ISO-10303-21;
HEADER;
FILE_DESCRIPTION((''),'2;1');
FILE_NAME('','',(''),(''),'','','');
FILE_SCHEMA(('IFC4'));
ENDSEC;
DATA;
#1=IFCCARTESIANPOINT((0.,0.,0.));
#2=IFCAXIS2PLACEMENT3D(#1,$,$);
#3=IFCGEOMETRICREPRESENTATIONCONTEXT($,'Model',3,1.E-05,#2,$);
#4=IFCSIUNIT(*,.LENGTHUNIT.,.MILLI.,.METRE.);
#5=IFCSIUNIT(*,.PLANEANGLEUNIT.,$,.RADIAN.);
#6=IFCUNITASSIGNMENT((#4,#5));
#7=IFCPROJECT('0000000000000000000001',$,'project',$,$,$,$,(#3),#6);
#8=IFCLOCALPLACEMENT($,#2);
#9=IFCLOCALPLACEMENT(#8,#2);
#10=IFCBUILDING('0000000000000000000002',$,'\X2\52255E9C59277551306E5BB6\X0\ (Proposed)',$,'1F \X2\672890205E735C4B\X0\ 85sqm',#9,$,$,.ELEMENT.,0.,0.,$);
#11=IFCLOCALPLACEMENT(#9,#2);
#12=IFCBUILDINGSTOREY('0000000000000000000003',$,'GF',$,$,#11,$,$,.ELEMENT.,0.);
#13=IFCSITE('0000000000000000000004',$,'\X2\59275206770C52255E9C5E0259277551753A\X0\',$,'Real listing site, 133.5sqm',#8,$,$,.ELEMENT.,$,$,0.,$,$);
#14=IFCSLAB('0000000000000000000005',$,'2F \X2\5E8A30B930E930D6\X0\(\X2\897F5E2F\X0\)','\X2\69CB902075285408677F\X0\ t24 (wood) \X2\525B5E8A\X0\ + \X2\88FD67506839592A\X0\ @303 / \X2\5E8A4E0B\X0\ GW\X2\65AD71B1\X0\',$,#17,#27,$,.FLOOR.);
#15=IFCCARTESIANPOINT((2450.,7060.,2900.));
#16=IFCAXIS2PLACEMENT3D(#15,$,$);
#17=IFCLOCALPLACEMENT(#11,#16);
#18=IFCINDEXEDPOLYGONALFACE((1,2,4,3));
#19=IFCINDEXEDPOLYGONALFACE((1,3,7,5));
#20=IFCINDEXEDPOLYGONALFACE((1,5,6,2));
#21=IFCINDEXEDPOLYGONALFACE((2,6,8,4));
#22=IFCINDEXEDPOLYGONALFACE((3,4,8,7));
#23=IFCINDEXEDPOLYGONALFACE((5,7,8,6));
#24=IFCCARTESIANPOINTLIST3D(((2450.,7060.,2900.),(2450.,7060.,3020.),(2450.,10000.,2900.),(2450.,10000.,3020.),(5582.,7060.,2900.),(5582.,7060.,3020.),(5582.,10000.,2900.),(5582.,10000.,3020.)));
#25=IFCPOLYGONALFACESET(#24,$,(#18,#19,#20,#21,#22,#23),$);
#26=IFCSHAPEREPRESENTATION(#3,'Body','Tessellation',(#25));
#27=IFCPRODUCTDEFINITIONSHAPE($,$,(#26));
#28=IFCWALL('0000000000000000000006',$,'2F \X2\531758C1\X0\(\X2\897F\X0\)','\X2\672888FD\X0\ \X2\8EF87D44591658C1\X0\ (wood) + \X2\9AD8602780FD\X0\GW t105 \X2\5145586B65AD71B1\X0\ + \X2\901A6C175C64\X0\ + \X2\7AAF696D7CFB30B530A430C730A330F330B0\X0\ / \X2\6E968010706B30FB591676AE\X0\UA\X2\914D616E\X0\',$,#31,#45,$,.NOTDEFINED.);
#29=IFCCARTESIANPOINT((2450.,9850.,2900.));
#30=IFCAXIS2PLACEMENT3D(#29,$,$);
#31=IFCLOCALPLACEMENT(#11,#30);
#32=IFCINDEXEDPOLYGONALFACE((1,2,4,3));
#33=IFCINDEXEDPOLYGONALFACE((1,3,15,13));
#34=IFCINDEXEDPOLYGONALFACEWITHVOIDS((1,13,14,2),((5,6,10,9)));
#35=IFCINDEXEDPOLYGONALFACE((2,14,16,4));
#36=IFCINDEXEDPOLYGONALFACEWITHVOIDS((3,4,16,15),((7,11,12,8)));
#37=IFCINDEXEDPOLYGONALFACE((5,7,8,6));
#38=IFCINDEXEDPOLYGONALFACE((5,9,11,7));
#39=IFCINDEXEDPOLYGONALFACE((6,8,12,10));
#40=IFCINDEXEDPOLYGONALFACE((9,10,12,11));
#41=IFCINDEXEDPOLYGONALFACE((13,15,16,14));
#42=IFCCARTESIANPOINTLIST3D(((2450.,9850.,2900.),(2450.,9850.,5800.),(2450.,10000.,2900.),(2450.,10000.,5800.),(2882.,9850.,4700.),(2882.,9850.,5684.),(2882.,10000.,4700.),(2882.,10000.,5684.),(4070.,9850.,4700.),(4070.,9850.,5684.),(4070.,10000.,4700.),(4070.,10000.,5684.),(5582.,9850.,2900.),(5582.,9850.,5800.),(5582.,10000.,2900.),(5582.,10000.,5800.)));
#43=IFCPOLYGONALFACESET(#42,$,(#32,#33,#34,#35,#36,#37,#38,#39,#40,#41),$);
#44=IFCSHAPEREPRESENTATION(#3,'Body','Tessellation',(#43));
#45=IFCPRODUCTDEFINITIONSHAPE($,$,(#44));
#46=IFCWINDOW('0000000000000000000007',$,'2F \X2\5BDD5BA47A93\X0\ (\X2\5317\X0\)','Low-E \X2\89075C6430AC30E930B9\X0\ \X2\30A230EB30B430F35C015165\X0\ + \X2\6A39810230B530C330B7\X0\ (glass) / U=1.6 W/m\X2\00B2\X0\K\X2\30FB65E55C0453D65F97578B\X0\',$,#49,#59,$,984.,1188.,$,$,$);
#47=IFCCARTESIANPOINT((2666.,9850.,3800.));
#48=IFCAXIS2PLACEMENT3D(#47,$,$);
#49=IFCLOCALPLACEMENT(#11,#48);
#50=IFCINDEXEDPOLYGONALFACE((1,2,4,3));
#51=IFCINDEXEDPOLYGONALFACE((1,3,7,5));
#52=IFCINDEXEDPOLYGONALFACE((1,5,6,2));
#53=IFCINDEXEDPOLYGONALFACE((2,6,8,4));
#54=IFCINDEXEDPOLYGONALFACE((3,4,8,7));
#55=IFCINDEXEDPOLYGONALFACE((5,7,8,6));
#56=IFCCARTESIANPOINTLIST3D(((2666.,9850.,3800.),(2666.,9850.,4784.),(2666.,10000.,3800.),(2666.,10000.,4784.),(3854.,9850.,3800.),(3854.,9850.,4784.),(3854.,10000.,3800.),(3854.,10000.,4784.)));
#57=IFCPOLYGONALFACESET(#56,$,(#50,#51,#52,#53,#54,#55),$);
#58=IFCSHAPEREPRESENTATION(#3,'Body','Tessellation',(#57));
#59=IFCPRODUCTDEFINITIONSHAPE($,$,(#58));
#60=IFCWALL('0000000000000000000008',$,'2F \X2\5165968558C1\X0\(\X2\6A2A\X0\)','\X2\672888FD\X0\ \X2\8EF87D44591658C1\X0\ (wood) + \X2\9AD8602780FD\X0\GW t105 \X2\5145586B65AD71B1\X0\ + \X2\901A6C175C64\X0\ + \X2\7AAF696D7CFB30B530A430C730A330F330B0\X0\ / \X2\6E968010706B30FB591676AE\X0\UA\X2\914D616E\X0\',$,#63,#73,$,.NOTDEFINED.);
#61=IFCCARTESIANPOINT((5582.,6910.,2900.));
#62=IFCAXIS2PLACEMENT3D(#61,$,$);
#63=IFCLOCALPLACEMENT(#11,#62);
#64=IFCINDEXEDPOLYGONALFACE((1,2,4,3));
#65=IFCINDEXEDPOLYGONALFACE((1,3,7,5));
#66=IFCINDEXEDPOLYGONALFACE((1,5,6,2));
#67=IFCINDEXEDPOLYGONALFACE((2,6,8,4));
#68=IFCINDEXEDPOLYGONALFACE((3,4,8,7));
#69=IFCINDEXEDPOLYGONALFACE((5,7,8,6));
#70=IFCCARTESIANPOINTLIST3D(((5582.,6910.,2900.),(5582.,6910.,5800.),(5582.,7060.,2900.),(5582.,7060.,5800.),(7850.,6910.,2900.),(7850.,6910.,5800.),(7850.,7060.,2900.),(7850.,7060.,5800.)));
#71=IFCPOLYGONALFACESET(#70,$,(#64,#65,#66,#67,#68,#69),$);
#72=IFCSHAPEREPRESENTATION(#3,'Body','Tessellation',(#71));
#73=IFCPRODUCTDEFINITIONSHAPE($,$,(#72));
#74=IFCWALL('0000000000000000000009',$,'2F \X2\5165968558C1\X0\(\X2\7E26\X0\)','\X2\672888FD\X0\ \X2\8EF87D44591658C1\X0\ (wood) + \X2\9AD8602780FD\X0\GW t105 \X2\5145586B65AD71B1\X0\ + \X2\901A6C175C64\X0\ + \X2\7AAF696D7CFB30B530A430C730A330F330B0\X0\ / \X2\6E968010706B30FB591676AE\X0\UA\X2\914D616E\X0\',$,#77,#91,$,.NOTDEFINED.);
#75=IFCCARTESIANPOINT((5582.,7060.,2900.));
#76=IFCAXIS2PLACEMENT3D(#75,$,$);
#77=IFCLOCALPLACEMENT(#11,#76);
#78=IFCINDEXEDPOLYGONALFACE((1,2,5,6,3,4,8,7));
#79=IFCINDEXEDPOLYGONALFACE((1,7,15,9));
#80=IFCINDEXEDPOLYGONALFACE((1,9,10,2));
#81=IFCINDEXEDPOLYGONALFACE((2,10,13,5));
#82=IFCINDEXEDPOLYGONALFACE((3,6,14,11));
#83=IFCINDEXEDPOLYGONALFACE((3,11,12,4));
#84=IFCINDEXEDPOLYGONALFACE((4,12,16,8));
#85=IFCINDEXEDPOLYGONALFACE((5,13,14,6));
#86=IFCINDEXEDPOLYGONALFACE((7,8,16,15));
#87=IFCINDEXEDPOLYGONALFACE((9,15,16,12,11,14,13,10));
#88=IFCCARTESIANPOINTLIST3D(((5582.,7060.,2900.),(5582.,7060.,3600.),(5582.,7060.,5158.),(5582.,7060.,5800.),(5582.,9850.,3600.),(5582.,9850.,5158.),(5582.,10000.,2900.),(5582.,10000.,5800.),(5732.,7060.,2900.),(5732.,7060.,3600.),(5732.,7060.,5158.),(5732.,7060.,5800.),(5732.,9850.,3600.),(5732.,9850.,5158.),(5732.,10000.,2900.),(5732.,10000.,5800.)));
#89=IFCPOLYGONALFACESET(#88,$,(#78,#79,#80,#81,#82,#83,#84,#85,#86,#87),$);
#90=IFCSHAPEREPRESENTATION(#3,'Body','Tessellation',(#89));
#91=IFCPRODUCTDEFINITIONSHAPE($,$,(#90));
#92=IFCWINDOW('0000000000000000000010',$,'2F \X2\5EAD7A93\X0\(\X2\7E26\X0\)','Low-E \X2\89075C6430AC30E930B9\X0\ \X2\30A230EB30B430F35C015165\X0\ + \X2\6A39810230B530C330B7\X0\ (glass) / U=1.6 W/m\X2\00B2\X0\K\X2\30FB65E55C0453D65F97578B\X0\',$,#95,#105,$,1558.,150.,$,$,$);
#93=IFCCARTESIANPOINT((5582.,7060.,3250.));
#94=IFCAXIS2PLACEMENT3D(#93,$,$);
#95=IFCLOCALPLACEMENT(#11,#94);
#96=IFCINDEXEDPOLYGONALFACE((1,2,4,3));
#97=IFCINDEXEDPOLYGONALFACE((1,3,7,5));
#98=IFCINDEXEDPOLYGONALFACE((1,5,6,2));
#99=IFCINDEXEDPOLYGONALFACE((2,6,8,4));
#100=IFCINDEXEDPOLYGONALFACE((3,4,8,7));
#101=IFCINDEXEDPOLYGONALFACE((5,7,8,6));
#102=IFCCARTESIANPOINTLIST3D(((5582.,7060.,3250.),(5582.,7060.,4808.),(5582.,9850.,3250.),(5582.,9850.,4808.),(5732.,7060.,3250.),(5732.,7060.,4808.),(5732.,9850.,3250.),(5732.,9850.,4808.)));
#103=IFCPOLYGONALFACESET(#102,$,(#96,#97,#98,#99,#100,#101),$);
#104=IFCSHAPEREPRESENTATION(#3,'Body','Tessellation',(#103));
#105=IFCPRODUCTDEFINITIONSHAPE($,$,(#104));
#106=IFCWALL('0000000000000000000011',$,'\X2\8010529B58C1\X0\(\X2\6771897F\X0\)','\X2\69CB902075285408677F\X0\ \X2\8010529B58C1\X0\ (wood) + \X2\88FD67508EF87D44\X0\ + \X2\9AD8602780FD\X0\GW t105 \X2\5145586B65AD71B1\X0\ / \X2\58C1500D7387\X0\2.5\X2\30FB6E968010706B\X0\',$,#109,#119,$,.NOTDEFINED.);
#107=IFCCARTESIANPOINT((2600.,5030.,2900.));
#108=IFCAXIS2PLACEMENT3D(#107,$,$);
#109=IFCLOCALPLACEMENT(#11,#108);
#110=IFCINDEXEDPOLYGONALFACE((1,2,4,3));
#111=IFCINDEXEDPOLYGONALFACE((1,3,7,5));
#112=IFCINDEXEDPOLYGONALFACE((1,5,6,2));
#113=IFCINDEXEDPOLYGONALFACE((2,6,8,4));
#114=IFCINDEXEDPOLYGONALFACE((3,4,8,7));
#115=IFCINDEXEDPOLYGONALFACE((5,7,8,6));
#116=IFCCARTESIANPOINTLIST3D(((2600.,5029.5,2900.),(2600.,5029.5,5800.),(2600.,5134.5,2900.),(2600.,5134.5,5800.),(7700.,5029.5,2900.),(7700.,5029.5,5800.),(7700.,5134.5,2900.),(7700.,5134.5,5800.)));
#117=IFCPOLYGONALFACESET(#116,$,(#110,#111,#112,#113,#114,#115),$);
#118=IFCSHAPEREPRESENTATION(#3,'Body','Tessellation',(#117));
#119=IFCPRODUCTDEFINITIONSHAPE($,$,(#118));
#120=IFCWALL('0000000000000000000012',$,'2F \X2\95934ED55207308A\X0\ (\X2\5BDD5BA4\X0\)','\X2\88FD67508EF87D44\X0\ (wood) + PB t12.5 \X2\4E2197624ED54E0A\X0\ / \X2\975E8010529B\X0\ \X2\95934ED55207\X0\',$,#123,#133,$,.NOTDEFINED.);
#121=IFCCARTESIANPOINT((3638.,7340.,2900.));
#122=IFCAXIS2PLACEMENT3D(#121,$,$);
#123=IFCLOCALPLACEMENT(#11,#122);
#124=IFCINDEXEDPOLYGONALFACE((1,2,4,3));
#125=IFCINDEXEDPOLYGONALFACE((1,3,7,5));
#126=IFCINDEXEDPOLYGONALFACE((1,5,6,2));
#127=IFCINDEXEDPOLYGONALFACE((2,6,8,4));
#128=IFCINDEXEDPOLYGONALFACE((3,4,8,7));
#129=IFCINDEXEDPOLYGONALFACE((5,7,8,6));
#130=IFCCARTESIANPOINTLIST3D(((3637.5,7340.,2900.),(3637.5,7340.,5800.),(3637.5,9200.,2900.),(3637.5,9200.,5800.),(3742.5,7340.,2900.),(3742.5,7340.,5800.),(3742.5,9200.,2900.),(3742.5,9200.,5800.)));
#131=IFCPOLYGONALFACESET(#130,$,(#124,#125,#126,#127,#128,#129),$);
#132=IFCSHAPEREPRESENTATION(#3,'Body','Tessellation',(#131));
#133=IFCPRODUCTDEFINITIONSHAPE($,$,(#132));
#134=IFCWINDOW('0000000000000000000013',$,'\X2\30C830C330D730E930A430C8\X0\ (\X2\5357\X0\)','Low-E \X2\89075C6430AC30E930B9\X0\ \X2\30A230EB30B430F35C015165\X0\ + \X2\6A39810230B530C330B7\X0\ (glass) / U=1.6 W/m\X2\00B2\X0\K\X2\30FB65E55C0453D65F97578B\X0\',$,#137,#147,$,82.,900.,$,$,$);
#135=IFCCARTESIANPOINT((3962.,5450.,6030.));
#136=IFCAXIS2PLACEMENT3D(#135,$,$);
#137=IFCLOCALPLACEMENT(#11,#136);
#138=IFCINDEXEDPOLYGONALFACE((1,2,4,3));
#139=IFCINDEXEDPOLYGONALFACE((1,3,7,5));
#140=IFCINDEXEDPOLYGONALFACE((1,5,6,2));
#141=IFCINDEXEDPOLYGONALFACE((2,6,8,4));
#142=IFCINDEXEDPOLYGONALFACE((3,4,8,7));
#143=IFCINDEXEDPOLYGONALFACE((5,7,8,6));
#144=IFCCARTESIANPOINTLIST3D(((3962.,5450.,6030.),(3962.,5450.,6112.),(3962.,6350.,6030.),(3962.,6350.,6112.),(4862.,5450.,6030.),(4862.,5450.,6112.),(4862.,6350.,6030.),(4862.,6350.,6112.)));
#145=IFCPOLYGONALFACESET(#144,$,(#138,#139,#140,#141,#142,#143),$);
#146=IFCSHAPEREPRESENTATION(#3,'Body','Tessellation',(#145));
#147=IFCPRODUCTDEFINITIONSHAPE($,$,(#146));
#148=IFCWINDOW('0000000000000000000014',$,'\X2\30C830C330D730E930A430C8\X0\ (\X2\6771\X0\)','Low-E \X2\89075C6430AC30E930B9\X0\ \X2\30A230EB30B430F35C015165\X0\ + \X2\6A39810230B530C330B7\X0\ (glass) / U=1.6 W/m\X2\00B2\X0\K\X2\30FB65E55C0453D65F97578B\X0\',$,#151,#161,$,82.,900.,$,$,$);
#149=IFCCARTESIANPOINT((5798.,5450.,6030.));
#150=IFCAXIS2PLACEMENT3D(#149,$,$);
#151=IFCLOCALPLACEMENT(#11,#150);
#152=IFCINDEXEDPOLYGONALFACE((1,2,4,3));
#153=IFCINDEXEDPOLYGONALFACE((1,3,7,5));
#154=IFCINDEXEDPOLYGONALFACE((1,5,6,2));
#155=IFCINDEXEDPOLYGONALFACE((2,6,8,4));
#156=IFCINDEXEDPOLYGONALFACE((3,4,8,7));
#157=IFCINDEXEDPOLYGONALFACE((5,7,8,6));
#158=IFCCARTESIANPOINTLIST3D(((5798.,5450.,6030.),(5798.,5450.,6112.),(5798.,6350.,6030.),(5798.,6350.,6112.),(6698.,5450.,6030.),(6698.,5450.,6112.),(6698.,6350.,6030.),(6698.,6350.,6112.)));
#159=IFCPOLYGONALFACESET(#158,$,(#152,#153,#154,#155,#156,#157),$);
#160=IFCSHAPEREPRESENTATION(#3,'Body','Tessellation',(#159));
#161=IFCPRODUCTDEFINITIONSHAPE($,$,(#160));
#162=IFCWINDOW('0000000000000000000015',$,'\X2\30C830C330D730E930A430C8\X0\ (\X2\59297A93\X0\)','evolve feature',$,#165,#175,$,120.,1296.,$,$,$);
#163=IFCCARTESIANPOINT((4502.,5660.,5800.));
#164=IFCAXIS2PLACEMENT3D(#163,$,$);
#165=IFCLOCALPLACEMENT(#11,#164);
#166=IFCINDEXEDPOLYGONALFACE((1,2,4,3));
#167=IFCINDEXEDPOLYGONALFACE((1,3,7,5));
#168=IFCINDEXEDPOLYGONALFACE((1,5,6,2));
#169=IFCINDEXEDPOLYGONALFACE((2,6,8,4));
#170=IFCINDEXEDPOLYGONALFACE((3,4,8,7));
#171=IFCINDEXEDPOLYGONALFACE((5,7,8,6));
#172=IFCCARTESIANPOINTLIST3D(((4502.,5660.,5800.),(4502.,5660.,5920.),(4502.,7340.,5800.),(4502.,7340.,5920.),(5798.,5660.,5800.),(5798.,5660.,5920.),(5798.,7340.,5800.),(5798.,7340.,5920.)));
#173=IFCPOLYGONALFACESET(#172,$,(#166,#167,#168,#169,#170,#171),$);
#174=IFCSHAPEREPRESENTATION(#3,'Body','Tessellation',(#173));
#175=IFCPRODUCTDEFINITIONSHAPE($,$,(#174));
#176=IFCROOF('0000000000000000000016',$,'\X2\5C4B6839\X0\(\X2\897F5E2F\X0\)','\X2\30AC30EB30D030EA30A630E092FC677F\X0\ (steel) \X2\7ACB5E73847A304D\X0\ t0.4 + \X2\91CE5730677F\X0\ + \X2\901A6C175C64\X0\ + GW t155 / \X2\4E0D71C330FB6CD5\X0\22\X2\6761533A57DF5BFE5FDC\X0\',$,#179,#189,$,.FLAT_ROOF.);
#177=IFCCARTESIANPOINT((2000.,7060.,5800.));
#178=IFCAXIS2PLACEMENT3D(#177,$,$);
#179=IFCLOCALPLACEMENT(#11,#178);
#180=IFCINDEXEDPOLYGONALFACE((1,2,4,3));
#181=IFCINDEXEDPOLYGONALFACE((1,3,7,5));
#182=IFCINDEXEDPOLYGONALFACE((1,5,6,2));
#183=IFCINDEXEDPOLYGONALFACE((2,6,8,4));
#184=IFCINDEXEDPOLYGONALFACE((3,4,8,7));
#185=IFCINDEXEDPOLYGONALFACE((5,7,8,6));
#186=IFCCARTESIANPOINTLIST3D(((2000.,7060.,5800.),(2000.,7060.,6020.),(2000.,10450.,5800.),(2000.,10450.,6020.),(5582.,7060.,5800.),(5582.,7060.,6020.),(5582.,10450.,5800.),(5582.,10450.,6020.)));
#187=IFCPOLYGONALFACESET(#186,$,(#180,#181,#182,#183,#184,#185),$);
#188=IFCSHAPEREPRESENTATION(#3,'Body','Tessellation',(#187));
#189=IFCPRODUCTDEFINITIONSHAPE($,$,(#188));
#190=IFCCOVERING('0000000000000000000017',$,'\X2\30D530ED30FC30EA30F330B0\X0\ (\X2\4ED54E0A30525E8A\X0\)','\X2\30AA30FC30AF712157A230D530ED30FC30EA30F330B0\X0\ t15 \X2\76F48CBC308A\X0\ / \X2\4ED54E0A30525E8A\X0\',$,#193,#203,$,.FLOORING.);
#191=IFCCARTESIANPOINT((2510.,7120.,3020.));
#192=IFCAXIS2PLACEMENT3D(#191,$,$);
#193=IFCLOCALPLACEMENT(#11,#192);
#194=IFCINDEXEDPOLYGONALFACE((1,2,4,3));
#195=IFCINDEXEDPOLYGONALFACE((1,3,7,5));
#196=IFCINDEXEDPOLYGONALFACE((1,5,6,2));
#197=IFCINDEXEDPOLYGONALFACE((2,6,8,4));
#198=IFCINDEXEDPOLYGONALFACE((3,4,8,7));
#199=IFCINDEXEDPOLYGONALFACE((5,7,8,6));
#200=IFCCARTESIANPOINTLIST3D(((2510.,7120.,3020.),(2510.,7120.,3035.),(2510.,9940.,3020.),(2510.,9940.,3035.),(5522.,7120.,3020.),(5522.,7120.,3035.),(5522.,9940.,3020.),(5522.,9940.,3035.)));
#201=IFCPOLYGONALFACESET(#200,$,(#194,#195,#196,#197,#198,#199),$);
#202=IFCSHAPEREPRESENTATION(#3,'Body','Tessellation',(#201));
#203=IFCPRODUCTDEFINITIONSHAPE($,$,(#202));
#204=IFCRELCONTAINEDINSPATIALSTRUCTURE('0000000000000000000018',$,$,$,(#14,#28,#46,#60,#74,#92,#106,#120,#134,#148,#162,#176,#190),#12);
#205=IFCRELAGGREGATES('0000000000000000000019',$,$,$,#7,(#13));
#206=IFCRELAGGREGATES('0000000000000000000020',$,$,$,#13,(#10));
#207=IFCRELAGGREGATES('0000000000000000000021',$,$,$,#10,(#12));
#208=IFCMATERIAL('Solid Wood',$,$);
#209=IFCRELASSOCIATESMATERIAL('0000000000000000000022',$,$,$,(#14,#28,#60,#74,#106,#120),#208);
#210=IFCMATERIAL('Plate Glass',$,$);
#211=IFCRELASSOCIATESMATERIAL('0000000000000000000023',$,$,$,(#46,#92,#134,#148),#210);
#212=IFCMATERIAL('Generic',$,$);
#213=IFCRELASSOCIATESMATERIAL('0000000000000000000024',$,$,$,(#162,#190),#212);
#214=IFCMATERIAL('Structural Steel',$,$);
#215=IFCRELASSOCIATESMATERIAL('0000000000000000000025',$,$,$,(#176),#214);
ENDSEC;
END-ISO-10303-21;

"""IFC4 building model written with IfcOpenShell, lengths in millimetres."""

from ifc_helpers import new_model, si_unit, frame, frame_2d, origin, place, context, project, spatial, rectangle, extrude, material, element, fill, save


model = new_model("IFC4")

# Units and contexts
model_context = context("Model", 3, precision=1e-05, world=origin())
ifc_project = project(units=[si_unit("LENGTHUNIT", "METRE", prefix="MILLI"), si_unit("PLANEANGLEUNIT", "RADIAN")], contexts=[model_context])

# Site, building, storey
site_placement = place(None, origin())
site = spatial("IfcSite", under=ifc_project, at=site_placement, Name="大分県別府市大畑町", ObjectType="Real listing site, 133.5sqm", CompositionType="ELEMENT", RefElevation=0.0)
building_placement = place(site_placement, origin())
building = spatial("IfcBuilding", under=site, at=building_placement, Name="別府大畑の家 (Proposed)", ObjectType="1F 木造平屋 85sqm", CompositionType="ELEMENT", ElevationOfRefHeight=0.0, ElevationOfTerrain=0.0)
storey_placement = place(building_placement, origin())
storey = spatial("IfcBuildingStorey", under=building, at=storey_placement, Name="GF", CompositionType="ELEMENT", Elevation=0.0)

# Slab
ifc_material_1 = material(Name="Solid Wood")
slab_placement = place(storey_placement, frame((2450.0, 7060.0, 2900.0)))
element("IfcSlab", 1, at=slab_placement, inside=storey, material=ifc_material_1, Name="2F 床スラブ(西帯)", Description="構造用合板 t24 (wood) 剛床 + 製材根太 @303 / 床下 GW断熱", PredefinedType="FLOOR", context=model_context, shape_type="SweptSolid", body=[
    extrude(rectangle(XDim=3132.0, YDim=2940.0, at=frame_2d((1566.0, 1470.0))), frame((2450.0, 7060.0, 2900.0)), (0.0, 0.0, 1.0), 120.0),
])

# Wall, opening, window
wall_1_placement = place(storey_placement, frame((2450.0, 9850.0, 2900.0)))
wall_1 = element("IfcWall", 2, at=wall_1_placement, inside=storey, material=ifc_material_1, Name="2F 北壁(西)", Description="木製 軸組外壁 (wood) + 高性能GW t105 充填断熱 + 通気層 + 窯業系サイディング / 準耐火・外皮UA配慮", PredefinedType="NOTDEFINED", context=model_context, shape_type="SweptSolid", body=[
    extrude(rectangle(XDim=3132.0, YDim=150.0, at=frame_2d((1566.0, 75.0))), frame((2450.0, 9850.0, 2900.0)), (0.0, 0.0, 1.0), 2900.0),
])
opening_1_placement = place(storey_placement, frame((2666.0, 9850.0, 3800.0)))
opening_1 = element("IfcOpeningElement", 3, at=opening_1_placement, cuts=wall_1, PredefinedType="NOTDEFINED", context=model_context, shape_type="SweptSolid", body=[
    extrude(rectangle(XDim=1188.0, YDim=150.0, at=frame_2d((594.0, 75.0))), frame((2666.0, 9850.0, 3800.0)), (0.0, 0.0, 1.0), 984.0),
])
ifc_material_2 = material(Name="Plate Glass")
window_1_placement = place(storey_placement, frame((2666.0, 9850.0, 3800.0)))
window_1 = element("IfcWindow", 4, at=window_1_placement, inside=storey, material=ifc_material_2, Name="2F 寝室窓 (北)", Description="Low-E 複層ガラス アルゴン封入 + 樹脂サッシ (glass) / U=1.6 W/m²K・日射取得型", OverallHeight=984.0, OverallWidth=1188.0, context=model_context, shape_type="SweptSolid", body=[
    extrude(rectangle(XDim=1188.0, YDim=150.0, at=frame_2d((594.0, 75.0))), frame((2666.0, 9850.0, 3800.0)), (0.0, 0.0, 1.0), 984.0),
])
fill(opening_1, window_1)

# Wall
wall_2_placement = place(storey_placement, frame((5582.0, 6910.0, 2900.0)))
element("IfcWall", 5, at=wall_2_placement, inside=storey, material=ifc_material_1, Name="2F 入隅壁(横)", Description="木製 軸組外壁 (wood) + 高性能GW t105 充填断熱 + 通気層 + 窯業系サイディング / 準耐火・外皮UA配慮", PredefinedType="NOTDEFINED", context=model_context, shape_type="SweptSolid", body=[
    extrude(rectangle(XDim=2268.0, YDim=150.0, at=frame_2d((1134.0, 75.0))), frame((5582.0, 6910.0, 2900.0)), (0.0, 0.0, 1.0), 2900.0),
])

# Wall, opening, window
wall_3_placement = place(storey_placement, frame((5582.0, 7060.0, 2900.0)))
wall_3 = element("IfcWall", 6, at=wall_3_placement, inside=storey, material=ifc_material_1, Name="2F 入隅壁(縦)", Description="木製 軸組外壁 (wood) + 高性能GW t105 充填断熱 + 通気層 + 窯業系サイディング / 準耐火・外皮UA配慮", PredefinedType="NOTDEFINED", context=model_context, shape_type="SweptSolid", body=[
    extrude(rectangle(XDim=150.0, YDim=2940.0, at=frame_2d((75.0, 1470.0))), frame((5582.0, 7060.0, 2900.0)), (0.0, 0.0, 1.0), 2900.0),
])
opening_2_placement = place(storey_placement, frame((5582.0, 7060.0, 3250.0)))
opening_2 = element("IfcOpeningElement", 7, at=opening_2_placement, cuts=wall_3, PredefinedType="NOTDEFINED", context=model_context, shape_type="SweptSolid", body=[
    extrude(rectangle(XDim=150.0, YDim=2790.0, at=frame_2d((75.0, 1395.0))), frame((5582.0, 7060.0, 3250.0)), (0.0, 0.0, 1.0), 1558.0),
])
window_2_placement = place(storey_placement, frame((5582.0, 7060.0, 3250.0)))
window_2 = element("IfcWindow", 8, at=window_2_placement, inside=storey, material=ifc_material_2, Name="2F 庭窓(縦)", Description="Low-E 複層ガラス アルゴン封入 + 樹脂サッシ (glass) / U=1.6 W/m²K・日射取得型", OverallHeight=1558.0, OverallWidth=150.0, context=model_context, shape_type="SweptSolid", body=[
    extrude(rectangle(XDim=150.0, YDim=2790.0, at=frame_2d((75.0, 1395.0))), frame((5582.0, 7060.0, 3250.0)), (0.0, 0.0, 1.0), 1558.0),
])
fill(opening_2, window_2)

# Walls
wall_4_placement = place(storey_placement, frame((2600.0, 5030.0, 2900.0)))
element("IfcWall", 9, at=wall_4_placement, inside=storey, material=ifc_material_1, Name="耐力壁(東西)", Description="構造用合板 耐力壁 (wood) + 製材軸組 + 高性能GW t105 充填断熱 / 壁倍率2.5・準耐火", PredefinedType="NOTDEFINED", context=model_context, shape_type="SweptSolid", body=[
    extrude(rectangle(XDim=5100.0, YDim=105.0, at=frame_2d((2550.0, 52.0))), frame((2600.0, 5030.0, 2900.0)), (0.0, 0.0, 1.0), 2900.0),
])
wall_5_placement = place(storey_placement, frame((3638.0, 7340.0, 2900.0)))
element("IfcWall", 10, at=wall_5_placement, inside=storey, material=ifc_material_1, Name="2F 間仕切り (寝室)", Description="製材軸組 (wood) + PB t12.5 両面仕上 / 非耐力 間仕切", PredefinedType="NOTDEFINED", context=model_context, shape_type="SweptSolid", body=[
    extrude(rectangle(XDim=105.0, YDim=1860.0, at=frame_2d((52.0, 930.0))), frame((3638.0, 7340.0, 2900.0)), (0.0, 0.0, 1.0), 2900.0),
])

# Windows
window_3_placement = place(storey_placement, frame((3962.0, 5450.0, 6030.0)))
element("IfcWindow", 11, at=window_3_placement, inside=storey, material=ifc_material_2, Name="トップライト (南)", Description="Low-E 複層ガラス アルゴン封入 + 樹脂サッシ (glass) / U=1.6 W/m²K・日射取得型", OverallHeight=82.0, OverallWidth=900.0, context=model_context, shape_type="SweptSolid", body=[
    extrude(rectangle(XDim=900.0, YDim=900.0, at=frame_2d((450.0, 450.0))), frame((3962.0, 5450.0, 6030.0)), (0.0, 0.0, 1.0), 82.0),
])
window_4_placement = place(storey_placement, frame((5798.0, 5450.0, 6030.0)))
element("IfcWindow", 12, at=window_4_placement, inside=storey, material=ifc_material_2, Name="トップライト (東)", Description="Low-E 複層ガラス アルゴン封入 + 樹脂サッシ (glass) / U=1.6 W/m²K・日射取得型", OverallHeight=82.0, OverallWidth=900.0, context=model_context, shape_type="SweptSolid", body=[
    extrude(rectangle(XDim=900.0, YDim=900.0, at=frame_2d((450.0, 450.0))), frame((5798.0, 5450.0, 6030.0)), (0.0, 0.0, 1.0), 82.0),
])
ifc_material_3 = material(Name="Generic")
window_5_placement = place(storey_placement, frame((4502.0, 5660.0, 5800.0)))
element("IfcWindow", 13, at=window_5_placement, inside=storey, material=ifc_material_3, Name="トップライト (天窓)", Description="evolve feature", OverallHeight=120.0, OverallWidth=1296.0, context=model_context, shape_type="SweptSolid", body=[
    extrude(rectangle(XDim=1296.0, YDim=1680.0, at=frame_2d((648.0, 840.0))), frame((4502.0, 5660.0, 5800.0)), (0.0, 0.0, 1.0), 120.0),
])

# Roof
ifc_material_4 = material(Name="Structural Steel")
for number, where, name in (
    (14, (2000.0, 7060.0, 5800.0), "屋根(西帯)"),
):
    element("IfcRoof", number, at=place(storey_placement, frame(where)), inside=storey, material=ifc_material_4, Name=name, Description="ガルバリウム鋼板 (steel) 立平葺き t0.4 + 野地板 + 通気層 + GW t155 / 不燃・法22条区域対応", PredefinedType="FLAT_ROOF", context=model_context, shape_type="SweptSolid", body=[
        extrude(rectangle(XDim=3582.0, YDim=3390.0, at=frame_2d((1791.0, 1695.0))), frame((2000.0, 7060.0, 5800.0)), (0.0, 0.0, 1.0), 220.0),
    ])

# Covering
covering_placement = place(storey_placement, frame((2510.0, 7120.0, 3020.0)))
element("IfcCovering", 15, at=covering_placement, inside=storey, material=ifc_material_3, Name="フローリング (仕上げ床)", Description="オーク無垢フローリング t15 直貼り / 仕上げ床", PredefinedType="FLOORING", context=model_context, shape_type="SweptSolid", body=[
    extrude(rectangle(XDim=3012.0, YDim=2820.0, at=frame_2d((1506.0, 1410.0))), frame((2510.0, 7120.0, 3020.0)), (0.0, 0.0, 1.0), 15.0),
])

save(model, "model.ifc")
